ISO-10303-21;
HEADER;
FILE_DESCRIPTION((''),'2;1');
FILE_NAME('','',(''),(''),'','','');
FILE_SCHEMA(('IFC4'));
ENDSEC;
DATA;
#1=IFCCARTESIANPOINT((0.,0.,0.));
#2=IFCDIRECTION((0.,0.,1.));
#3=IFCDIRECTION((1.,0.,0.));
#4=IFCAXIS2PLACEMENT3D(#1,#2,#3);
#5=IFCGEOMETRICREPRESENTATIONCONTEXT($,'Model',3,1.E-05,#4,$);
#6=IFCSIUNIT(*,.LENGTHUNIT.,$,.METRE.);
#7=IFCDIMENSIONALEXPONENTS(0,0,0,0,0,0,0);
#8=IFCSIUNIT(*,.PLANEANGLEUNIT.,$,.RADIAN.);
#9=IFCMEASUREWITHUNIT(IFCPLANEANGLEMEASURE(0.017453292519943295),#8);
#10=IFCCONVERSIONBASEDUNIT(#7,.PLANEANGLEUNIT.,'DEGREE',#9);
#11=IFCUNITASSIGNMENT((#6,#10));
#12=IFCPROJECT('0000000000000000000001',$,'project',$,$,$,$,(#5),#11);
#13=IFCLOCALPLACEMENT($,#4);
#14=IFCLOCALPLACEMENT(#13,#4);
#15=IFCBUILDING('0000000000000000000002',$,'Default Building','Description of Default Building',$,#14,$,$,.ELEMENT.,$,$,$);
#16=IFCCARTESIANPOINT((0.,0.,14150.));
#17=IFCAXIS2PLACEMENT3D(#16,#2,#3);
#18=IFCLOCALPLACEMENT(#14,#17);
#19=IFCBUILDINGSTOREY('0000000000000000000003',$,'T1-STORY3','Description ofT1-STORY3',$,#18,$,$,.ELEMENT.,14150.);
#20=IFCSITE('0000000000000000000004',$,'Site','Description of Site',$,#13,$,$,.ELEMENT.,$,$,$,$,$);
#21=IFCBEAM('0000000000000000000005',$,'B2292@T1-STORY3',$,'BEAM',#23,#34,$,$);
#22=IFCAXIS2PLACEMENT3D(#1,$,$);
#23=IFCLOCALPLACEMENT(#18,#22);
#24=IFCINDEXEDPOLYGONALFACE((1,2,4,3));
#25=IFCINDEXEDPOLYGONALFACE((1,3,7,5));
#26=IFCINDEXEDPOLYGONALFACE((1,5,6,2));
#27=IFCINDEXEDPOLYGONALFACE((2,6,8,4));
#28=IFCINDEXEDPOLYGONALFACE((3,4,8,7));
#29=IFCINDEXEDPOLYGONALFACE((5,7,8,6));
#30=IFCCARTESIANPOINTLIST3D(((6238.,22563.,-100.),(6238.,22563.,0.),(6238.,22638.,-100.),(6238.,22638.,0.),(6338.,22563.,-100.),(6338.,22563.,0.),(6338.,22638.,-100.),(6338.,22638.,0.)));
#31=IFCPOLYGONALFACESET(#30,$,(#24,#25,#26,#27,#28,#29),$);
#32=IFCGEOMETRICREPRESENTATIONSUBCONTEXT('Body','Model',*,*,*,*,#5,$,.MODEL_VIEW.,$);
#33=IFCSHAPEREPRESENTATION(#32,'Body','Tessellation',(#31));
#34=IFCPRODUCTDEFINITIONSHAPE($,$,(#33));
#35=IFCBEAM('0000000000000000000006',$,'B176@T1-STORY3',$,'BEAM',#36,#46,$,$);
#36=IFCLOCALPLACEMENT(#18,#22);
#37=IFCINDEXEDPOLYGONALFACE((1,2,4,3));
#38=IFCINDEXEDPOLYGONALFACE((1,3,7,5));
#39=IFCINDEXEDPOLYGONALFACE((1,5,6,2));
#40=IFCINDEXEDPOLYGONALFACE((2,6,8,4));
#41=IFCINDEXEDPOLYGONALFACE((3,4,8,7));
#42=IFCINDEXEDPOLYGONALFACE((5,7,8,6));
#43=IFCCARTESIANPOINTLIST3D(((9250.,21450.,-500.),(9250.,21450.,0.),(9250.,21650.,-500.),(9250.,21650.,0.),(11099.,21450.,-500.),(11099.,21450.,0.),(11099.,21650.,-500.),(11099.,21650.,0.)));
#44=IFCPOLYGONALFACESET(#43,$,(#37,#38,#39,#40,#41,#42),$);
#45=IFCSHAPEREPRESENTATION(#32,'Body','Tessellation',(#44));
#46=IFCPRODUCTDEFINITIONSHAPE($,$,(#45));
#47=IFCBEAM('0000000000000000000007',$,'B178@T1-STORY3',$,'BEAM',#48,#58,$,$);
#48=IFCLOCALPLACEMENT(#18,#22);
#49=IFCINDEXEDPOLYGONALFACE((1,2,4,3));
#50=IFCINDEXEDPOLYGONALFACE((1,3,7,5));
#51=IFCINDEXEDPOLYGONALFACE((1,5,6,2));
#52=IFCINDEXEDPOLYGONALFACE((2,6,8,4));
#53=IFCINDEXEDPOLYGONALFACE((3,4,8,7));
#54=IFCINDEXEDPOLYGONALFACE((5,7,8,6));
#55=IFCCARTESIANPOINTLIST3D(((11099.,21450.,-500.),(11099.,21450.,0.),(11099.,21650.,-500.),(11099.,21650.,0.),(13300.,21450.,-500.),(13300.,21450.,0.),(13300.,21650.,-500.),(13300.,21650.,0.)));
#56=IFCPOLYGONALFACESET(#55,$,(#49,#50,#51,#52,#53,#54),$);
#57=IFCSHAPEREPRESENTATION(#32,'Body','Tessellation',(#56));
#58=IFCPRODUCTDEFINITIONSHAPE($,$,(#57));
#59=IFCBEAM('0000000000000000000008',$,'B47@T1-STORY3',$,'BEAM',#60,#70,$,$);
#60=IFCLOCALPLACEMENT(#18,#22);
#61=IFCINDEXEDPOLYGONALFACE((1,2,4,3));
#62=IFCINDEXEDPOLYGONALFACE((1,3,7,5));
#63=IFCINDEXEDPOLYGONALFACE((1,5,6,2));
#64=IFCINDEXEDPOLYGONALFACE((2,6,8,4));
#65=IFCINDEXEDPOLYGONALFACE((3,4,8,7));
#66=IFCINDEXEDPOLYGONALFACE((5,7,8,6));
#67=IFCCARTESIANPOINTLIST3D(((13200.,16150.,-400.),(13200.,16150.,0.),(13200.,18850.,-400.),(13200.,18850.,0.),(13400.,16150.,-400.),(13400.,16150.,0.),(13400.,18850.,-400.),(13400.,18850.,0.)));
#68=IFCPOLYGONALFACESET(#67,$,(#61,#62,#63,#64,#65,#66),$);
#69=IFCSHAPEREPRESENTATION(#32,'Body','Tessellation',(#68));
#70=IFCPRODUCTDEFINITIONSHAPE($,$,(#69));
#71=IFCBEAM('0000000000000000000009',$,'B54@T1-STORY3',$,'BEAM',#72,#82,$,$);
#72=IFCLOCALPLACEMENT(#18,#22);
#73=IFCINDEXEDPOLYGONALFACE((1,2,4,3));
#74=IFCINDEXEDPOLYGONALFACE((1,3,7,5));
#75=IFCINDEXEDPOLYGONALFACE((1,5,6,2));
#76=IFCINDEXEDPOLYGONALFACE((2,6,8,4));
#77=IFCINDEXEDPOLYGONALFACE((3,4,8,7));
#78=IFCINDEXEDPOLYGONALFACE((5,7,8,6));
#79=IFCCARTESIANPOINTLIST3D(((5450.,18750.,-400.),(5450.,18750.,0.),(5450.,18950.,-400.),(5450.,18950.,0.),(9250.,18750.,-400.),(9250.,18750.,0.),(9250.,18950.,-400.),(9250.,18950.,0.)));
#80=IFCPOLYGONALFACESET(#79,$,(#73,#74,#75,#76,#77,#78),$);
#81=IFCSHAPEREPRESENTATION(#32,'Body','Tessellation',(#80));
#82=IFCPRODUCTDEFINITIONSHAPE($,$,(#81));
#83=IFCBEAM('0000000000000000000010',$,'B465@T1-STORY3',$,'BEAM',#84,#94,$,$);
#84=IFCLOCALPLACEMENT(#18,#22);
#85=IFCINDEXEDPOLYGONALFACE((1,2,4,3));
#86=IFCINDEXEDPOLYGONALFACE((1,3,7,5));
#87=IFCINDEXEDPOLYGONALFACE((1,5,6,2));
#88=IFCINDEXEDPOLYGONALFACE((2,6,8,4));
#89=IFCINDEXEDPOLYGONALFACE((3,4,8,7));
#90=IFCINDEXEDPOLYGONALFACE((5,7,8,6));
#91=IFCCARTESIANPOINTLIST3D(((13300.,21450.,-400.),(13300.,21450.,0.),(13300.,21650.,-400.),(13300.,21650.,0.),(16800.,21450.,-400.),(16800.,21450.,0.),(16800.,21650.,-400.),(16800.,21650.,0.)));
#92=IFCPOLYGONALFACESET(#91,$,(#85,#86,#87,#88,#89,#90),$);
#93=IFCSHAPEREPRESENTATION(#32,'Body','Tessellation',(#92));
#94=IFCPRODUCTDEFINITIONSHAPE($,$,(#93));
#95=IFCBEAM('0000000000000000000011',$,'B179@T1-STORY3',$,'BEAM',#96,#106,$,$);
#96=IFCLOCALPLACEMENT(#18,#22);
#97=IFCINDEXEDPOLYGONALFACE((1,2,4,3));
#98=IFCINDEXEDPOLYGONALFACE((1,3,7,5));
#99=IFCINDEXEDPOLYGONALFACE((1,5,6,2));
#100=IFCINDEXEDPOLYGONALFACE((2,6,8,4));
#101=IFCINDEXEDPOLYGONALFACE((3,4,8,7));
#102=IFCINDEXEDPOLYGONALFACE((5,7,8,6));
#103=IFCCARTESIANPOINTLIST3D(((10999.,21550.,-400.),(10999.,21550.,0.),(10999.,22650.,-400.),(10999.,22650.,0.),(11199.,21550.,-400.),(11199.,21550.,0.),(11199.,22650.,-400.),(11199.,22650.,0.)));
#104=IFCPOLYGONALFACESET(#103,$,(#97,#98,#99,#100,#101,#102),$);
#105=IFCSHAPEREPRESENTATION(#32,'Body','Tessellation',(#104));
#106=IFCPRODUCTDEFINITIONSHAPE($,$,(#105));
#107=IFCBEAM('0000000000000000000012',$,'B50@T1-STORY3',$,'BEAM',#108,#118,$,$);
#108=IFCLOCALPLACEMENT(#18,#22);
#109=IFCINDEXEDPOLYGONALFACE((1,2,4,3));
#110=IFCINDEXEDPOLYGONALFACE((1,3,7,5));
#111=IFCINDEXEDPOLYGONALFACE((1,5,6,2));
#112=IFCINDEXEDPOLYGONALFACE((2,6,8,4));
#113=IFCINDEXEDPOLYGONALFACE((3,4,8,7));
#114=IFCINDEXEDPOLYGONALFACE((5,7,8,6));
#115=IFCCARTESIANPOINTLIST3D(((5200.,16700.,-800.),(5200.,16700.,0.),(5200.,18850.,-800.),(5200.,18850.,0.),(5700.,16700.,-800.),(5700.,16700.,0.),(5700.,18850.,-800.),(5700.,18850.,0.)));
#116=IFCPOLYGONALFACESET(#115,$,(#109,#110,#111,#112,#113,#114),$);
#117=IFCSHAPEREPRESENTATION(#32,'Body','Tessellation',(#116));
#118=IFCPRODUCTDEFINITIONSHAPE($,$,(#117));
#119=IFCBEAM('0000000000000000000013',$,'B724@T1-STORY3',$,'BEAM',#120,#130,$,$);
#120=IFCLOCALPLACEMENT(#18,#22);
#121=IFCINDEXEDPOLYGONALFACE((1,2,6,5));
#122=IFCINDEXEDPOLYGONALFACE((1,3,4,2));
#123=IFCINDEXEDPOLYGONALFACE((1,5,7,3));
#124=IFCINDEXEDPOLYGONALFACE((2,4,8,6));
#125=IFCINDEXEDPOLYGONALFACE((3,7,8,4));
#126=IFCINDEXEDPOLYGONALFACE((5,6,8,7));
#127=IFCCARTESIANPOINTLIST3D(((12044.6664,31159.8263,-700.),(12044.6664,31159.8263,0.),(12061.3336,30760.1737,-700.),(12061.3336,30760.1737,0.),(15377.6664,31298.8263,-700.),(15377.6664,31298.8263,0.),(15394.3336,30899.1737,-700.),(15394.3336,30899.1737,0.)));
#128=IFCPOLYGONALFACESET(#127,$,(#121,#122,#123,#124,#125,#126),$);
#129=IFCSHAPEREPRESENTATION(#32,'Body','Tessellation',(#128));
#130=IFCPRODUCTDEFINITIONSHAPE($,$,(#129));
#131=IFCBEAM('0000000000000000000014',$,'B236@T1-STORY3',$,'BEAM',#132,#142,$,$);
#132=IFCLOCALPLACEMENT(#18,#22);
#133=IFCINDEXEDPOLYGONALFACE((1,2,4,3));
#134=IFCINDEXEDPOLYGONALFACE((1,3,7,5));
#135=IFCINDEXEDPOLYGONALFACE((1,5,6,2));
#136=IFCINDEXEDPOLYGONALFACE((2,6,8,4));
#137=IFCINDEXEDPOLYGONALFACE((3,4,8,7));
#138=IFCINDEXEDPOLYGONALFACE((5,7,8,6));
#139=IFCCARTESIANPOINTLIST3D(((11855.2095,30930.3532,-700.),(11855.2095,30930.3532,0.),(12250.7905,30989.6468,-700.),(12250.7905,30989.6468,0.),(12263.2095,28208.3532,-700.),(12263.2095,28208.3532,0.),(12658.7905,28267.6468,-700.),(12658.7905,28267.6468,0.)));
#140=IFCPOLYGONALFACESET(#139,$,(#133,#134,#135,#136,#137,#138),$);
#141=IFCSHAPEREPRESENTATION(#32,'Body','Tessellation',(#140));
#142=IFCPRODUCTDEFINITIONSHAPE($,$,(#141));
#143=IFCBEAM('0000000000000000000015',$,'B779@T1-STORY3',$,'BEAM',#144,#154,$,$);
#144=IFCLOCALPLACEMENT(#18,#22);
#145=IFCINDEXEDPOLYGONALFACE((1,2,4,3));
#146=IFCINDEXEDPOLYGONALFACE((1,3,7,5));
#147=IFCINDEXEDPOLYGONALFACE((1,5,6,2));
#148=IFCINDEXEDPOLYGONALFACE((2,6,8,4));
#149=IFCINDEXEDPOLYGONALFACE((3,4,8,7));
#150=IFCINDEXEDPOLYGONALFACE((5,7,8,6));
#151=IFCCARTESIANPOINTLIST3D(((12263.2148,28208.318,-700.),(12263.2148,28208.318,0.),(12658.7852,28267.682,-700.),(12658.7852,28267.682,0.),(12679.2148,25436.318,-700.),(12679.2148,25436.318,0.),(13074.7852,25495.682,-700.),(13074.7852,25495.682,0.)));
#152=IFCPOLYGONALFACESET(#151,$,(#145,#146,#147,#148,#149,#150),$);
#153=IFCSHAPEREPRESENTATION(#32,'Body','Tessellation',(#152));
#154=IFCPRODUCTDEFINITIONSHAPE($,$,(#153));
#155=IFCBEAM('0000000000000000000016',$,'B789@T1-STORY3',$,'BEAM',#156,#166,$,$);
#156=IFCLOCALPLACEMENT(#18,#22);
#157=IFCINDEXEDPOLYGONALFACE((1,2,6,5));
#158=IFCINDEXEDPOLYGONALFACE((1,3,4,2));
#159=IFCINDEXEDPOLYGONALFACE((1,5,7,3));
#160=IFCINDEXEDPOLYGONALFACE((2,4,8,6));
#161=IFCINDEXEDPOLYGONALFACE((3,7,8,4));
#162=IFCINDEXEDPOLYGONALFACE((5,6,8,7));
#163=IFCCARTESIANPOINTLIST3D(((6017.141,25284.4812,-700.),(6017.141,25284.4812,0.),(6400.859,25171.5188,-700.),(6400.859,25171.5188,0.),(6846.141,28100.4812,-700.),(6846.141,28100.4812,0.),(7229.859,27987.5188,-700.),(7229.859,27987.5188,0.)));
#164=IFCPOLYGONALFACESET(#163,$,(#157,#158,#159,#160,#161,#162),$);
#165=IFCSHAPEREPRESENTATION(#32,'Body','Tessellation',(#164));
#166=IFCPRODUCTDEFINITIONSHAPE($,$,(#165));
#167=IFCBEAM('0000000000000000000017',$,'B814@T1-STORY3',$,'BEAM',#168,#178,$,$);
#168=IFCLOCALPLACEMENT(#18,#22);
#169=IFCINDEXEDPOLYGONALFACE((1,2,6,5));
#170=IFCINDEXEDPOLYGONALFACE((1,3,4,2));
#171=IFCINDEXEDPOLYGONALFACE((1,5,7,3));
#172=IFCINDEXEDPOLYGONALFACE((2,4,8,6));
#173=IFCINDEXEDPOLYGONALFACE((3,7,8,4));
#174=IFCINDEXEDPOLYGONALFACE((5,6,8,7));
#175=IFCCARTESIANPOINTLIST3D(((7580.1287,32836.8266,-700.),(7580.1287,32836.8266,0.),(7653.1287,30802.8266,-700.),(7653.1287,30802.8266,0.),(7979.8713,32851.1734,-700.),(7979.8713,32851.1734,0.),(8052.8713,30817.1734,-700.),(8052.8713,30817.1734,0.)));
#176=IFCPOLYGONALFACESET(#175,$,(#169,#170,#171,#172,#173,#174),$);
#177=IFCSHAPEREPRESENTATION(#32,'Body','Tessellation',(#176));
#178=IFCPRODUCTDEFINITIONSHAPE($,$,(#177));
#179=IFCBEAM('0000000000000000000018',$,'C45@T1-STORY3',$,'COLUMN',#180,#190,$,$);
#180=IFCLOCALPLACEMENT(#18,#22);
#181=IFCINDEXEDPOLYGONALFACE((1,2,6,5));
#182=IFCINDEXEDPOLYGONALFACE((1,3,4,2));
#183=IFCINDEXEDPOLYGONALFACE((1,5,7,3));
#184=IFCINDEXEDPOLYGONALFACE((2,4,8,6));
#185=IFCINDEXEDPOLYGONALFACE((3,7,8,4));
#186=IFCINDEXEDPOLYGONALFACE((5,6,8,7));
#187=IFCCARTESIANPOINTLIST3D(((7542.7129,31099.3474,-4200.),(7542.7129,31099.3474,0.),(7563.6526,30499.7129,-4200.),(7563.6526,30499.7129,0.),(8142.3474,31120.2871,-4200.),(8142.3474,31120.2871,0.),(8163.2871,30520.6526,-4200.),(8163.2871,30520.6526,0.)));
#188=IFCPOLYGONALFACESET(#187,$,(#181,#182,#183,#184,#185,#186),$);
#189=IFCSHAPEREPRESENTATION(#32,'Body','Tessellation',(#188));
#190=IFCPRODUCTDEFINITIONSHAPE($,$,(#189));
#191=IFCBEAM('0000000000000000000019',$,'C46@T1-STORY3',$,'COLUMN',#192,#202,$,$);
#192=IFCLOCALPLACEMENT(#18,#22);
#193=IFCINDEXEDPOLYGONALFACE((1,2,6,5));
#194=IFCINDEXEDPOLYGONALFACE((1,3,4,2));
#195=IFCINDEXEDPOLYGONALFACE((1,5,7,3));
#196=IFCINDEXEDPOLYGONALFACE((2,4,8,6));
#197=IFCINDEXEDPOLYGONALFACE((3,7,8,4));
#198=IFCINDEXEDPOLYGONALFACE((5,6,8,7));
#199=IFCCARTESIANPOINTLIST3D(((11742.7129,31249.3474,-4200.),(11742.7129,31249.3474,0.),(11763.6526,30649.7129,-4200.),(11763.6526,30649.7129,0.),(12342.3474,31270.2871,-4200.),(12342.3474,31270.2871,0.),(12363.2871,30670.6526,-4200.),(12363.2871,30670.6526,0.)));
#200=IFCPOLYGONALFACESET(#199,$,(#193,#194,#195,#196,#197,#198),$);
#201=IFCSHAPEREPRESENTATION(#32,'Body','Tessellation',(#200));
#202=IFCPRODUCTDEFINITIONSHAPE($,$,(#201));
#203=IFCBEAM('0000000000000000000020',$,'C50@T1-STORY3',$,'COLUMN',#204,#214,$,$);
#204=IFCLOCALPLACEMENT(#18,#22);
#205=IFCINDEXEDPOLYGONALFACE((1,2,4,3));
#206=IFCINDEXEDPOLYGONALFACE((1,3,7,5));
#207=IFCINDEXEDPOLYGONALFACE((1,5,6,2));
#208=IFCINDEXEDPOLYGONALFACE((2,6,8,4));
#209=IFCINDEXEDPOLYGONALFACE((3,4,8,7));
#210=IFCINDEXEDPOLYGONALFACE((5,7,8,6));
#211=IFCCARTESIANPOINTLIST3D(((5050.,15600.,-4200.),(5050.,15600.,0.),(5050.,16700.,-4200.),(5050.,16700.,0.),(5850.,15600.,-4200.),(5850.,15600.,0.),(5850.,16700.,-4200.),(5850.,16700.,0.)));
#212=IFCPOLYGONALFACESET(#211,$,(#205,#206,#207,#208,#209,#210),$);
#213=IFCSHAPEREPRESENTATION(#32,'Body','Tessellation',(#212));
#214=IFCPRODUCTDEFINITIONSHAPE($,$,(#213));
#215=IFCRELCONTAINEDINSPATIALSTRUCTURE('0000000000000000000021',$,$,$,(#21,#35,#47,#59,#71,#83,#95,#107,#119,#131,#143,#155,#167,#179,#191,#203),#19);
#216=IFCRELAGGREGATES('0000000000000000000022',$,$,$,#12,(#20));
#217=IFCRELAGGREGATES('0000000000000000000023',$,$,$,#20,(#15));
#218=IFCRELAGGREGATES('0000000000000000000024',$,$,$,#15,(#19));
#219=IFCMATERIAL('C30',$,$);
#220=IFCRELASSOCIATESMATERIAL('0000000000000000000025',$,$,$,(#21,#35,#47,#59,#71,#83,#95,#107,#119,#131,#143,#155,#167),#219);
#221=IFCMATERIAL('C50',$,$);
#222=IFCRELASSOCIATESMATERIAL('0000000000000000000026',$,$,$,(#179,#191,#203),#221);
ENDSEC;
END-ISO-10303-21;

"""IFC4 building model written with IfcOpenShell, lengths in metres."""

from ifc_helpers import new_model, entity, si_unit, converted_unit, frame, origin_with_axes, place, context, subcontext, project, spatial, rectangle, extrude, material, element, save


model = new_model("IFC4")

# Units and contexts
model_context = context("Model", 3, precision=1e-05, world=origin_with_axes())
body_context = subcontext(model_context, "Body", "Model", "MODEL_VIEW")
ifc_project = project(units=[si_unit("LENGTHUNIT", "METRE"), converted_unit("PLANEANGLEUNIT", "DEGREE", entity("IfcPlaneAngleMeasure", 0.017453292519943295), si_unit("PLANEANGLEUNIT", "RADIAN"), dimensions=[0, 0, 0, 0, 0, 0, 0])], contexts=[model_context])

# Site, building, storey
site_placement = place(None, origin_with_axes())
site = spatial("IfcSite", under=ifc_project, at=site_placement, Name="Site", Description="Description of Site", CompositionType="ELEMENT")
building_placement = place(site_placement, origin_with_axes())
building = spatial("IfcBuilding", under=site, at=building_placement, Name="Default Building", Description="Description of Default Building", CompositionType="ELEMENT")
storey_placement = place(building_placement, frame((0.0, 0.0, 14150.0), z_axis=(0.0, 0.0, 1.0), x_axis=(1.0, 0.0, 0.0)))
storey = spatial("IfcBuildingStorey", under=building, at=storey_placement, Name="T1-STORY3", Description="Description ofT1-STORY3", CompositionType="ELEMENT", Elevation=14150.0)

# Beams
ifc_material_1 = material(Name="C30")
beam_1_placement = place(storey_placement, frame((6288.0, 22563.0, -50.0), z_axis=(0.0, 1.0, 0.0), x_axis=(-1.0, 0.0, 0.0)))
element("IfcBeam", 1, at=beam_1_placement, inside=storey, material=ifc_material_1, Name="B2292@T1-STORY3", ObjectType="BEAM", context=body_context, shape_type="SweptSolid", body=[
    extrude(rectangle(XDim=100.0, YDim=100.0), origin_with_axes(), (0.0, 0.0, 1.0), 75.0),
])
beam_2_placement = place(storey_placement, frame((9250.0, 21550.0, -250.0), z_axis=(1.0, 0.0, 0.0), x_axis=(0.0, 1.0, 0.0)))
element("IfcBeam", 2, at=beam_2_placement, inside=storey, material=ifc_material_1, Name="B176@T1-STORY3", ObjectType="BEAM", context=body_context, shape_type="SweptSolid", body=[
    extrude(rectangle(XDim=200.0, YDim=500.0), origin_with_axes(), (0.0, 0.0, 1.0), 1849.0),
])
beam_3_placement = place(storey_placement, frame((11099.0, 21550.0, -250.0), z_axis=(1.0, 0.0, 0.0), x_axis=(0.0, 1.0, 0.0)))
element("IfcBeam", 3, at=beam_3_placement, inside=storey, material=ifc_material_1, Name="B178@T1-STORY3", ObjectType="BEAM", context=body_context, shape_type="SweptSolid", body=[
    extrude(rectangle(XDim=200.0, YDim=500.0), origin_with_axes(), (0.0, 0.0, 1.0), 2201.0),
])
beam_4_placement = place(storey_placement, frame((13300.0, 16150.0, -200.0), z_axis=(0.0, 1.0, 0.0), x_axis=(-1.0, 0.0, 0.0)))
element("IfcBeam", 4, at=beam_4_placement, inside=storey, material=ifc_material_1, Name="B47@T1-STORY3", ObjectType="BEAM", context=body_context, shape_type="SweptSolid", body=[
    extrude(rectangle(XDim=200.0, YDim=400.0), origin_with_axes(), (0.0, 0.0, 1.0), 2700.0),
])
beam_5_placement = place(storey_placement, frame((5450.0, 18850.0, -200.0), z_axis=(1.0, 0.0, 0.0), x_axis=(0.0, 1.0, 0.0)))
element("IfcBeam", 5, at=beam_5_placement, inside=storey, material=ifc_material_1, Name="B54@T1-STORY3", ObjectType="BEAM", context=body_context, shape_type="SweptSolid", body=[
    extrude(rectangle(XDim=200.0, YDim=400.0), origin_with_axes(), (0.0, 0.0, 1.0), 3800.0),
])
beam_6_placement = place(storey_placement, frame((13300.0, 21550.0, -200.0), z_axis=(1.0, 0.0, 0.0), x_axis=(0.0, 1.0, 0.0)))
element("IfcBeam", 6, at=beam_6_placement, inside=storey, material=ifc_material_1, Name="B465@T1-STORY3", ObjectType="BEAM", context=body_context, shape_type="SweptSolid", body=[
    extrude(rectangle(XDim=200.0, YDim=400.0), origin_with_axes(), (0.0, 0.0, 1.0), 3500.0),
])
beam_7_placement = place(storey_placement, frame((11099.0, 21550.0, -200.0), z_axis=(0.0, 1.0, 0.0), x_axis=(-1.0, 0.0, 0.0)))
element("IfcBeam", 7, at=beam_7_placement, inside=storey, material=ifc_material_1, Name="B179@T1-STORY3", ObjectType="BEAM", context=body_context, shape_type="SweptSolid", body=[
    extrude(rectangle(XDim=200.0, YDim=400.0), origin_with_axes(), (0.0, 0.0, 1.0), 1100.0),
])
beam_8_placement = place(storey_placement, frame((5450.0, 16700.0, -400.0), z_axis=(0.0, 1.0, 0.0), x_axis=(-1.0, 0.0, 0.0)))
element("IfcBeam", 8, at=beam_8_placement, inside=storey, material=ifc_material_1, Name="B50@T1-STORY3", ObjectType="BEAM", context=body_context, shape_type="SweptSolid", body=[
    extrude(rectangle(XDim=500.0, YDim=800.0), origin_with_axes(), (0.0, 0.0, 1.0), 2150.0),
])
beam_9_placement = place(storey_placement, frame((12053.0, 30960.0, -350.0), z_axis=(0.999132, 0.041668, 0.0), x_axis=(-0.041668, 0.999132, 0.0)))
element("IfcBeam", 9, at=beam_9_placement, inside=storey, material=ifc_material_1, Name="B724@T1-STORY3", ObjectType="BEAM", context=body_context, shape_type="SweptSolid", body=[
    extrude(rectangle(XDim=400.0, YDim=700.0), origin_with_axes(), (0.0, 0.0, 1.0), 3335.8972),
])
beam_10_placement = place(storey_placement, frame((12053.0, 30960.0, -350.0), z_axis=(0.148234, -0.988952, 0.0), x_axis=(0.988952, 0.148234, 0.0)))
element("IfcBeam", 10, at=beam_10_placement, inside=storey, material=ifc_material_1, Name="B236@T1-STORY3", ObjectType="BEAM", context=body_context, shape_type="SweptSolid", body=[
    extrude(rectangle(XDim=400.0, YDim=700.0), origin_with_axes(), (0.0, 0.0, 1.0), 2752.4077),
])
beam_11_placement = place(storey_placement, frame((12461.0, 28238.0, -350.0), z_axis=(0.14841, -0.988926, 0.0), x_axis=(0.988926, 0.14841, 0.0)))
element("IfcBeam", 11, at=beam_11_placement, inside=storey, material=ifc_material_1, Name="B779@T1-STORY3", ObjectType="BEAM", context=body_context, shape_type="SweptSolid", body=[
    extrude(rectangle(XDim=400.0, YDim=700.0), origin_with_axes(), (0.0, 0.0, 1.0), 2803.0412),
])
beam_12_placement = place(storey_placement, frame((6209.0, 25228.0, -350.0), z_axis=(0.282406, 0.959295, 0.0), x_axis=(-0.959295, 0.282406, 0.0)))
element("IfcBeam", 12, at=beam_12_placement, inside=storey, material=ifc_material_1, Name="B789@T1-STORY3", ObjectType="BEAM", context=body_context, shape_type="SweptSolid", body=[
    extrude(rectangle(XDim=400.0, YDim=700.0), origin_with_axes(), (0.0, 0.0, 1.0), 2935.4892),
])
beam_13_placement = place(storey_placement, frame((7780.0, 32844.0, -350.0), z_axis=(0.035867, -0.999357, 0.0), x_axis=(0.999357, 0.035867, 0.0)))
element("IfcBeam", 13, at=beam_13_placement, inside=storey, material=ifc_material_1, Name="B814@T1-STORY3", ObjectType="BEAM", context=body_context, shape_type="SweptSolid", body=[
    extrude(rectangle(XDim=400.0, YDim=700.0), origin_with_axes(), (0.0, 0.0, 1.0), 2035.3096),
])
ifc_material_2 = material(Name="C50")
for number, where, z_axis, x_axis, name in (
    (14, (7853.0, 30810.0, -4200.0), (0.0, 0.0, 1.0), (-0.999391, -0.034899, 0.0), "C45@T1-STORY3"),
    (15, (12053.0, 30960.0, -4200.0), (0.0, 0.0, 1.0), (-0.999391, -0.034899, 0.0), "C46@T1-STORY3"),
):
    element("IfcBeam", number, at=place(storey_placement, frame(where, z_axis=z_axis, x_axis=x_axis)), inside=storey, material=ifc_material_2, Name=name, ObjectType="COLUMN", context=body_context, shape_type="SweptSolid", body=[
        extrude(rectangle(XDim=600.0, YDim=600.0), origin_with_axes(), (0.0, 0.0, 1.0), 4200.0),
    ])
beam_14_placement = place(storey_placement, frame((5450.0, 16150.0, -4200.0), z_axis=(0.0, 0.0, 1.0), x_axis=(-1.0, 0.0, 0.0)))
element("IfcBeam", 16, at=beam_14_placement, inside=storey, material=ifc_material_2, Name="C50@T1-STORY3", ObjectType="COLUMN", context=body_context, shape_type="SweptSolid", body=[
    extrude(rectangle(XDim=800.0, YDim=1100.0), origin_with_axes(), (0.0, 0.0, 1.0), 4200.0),
])

save(model, "model.ifc")
